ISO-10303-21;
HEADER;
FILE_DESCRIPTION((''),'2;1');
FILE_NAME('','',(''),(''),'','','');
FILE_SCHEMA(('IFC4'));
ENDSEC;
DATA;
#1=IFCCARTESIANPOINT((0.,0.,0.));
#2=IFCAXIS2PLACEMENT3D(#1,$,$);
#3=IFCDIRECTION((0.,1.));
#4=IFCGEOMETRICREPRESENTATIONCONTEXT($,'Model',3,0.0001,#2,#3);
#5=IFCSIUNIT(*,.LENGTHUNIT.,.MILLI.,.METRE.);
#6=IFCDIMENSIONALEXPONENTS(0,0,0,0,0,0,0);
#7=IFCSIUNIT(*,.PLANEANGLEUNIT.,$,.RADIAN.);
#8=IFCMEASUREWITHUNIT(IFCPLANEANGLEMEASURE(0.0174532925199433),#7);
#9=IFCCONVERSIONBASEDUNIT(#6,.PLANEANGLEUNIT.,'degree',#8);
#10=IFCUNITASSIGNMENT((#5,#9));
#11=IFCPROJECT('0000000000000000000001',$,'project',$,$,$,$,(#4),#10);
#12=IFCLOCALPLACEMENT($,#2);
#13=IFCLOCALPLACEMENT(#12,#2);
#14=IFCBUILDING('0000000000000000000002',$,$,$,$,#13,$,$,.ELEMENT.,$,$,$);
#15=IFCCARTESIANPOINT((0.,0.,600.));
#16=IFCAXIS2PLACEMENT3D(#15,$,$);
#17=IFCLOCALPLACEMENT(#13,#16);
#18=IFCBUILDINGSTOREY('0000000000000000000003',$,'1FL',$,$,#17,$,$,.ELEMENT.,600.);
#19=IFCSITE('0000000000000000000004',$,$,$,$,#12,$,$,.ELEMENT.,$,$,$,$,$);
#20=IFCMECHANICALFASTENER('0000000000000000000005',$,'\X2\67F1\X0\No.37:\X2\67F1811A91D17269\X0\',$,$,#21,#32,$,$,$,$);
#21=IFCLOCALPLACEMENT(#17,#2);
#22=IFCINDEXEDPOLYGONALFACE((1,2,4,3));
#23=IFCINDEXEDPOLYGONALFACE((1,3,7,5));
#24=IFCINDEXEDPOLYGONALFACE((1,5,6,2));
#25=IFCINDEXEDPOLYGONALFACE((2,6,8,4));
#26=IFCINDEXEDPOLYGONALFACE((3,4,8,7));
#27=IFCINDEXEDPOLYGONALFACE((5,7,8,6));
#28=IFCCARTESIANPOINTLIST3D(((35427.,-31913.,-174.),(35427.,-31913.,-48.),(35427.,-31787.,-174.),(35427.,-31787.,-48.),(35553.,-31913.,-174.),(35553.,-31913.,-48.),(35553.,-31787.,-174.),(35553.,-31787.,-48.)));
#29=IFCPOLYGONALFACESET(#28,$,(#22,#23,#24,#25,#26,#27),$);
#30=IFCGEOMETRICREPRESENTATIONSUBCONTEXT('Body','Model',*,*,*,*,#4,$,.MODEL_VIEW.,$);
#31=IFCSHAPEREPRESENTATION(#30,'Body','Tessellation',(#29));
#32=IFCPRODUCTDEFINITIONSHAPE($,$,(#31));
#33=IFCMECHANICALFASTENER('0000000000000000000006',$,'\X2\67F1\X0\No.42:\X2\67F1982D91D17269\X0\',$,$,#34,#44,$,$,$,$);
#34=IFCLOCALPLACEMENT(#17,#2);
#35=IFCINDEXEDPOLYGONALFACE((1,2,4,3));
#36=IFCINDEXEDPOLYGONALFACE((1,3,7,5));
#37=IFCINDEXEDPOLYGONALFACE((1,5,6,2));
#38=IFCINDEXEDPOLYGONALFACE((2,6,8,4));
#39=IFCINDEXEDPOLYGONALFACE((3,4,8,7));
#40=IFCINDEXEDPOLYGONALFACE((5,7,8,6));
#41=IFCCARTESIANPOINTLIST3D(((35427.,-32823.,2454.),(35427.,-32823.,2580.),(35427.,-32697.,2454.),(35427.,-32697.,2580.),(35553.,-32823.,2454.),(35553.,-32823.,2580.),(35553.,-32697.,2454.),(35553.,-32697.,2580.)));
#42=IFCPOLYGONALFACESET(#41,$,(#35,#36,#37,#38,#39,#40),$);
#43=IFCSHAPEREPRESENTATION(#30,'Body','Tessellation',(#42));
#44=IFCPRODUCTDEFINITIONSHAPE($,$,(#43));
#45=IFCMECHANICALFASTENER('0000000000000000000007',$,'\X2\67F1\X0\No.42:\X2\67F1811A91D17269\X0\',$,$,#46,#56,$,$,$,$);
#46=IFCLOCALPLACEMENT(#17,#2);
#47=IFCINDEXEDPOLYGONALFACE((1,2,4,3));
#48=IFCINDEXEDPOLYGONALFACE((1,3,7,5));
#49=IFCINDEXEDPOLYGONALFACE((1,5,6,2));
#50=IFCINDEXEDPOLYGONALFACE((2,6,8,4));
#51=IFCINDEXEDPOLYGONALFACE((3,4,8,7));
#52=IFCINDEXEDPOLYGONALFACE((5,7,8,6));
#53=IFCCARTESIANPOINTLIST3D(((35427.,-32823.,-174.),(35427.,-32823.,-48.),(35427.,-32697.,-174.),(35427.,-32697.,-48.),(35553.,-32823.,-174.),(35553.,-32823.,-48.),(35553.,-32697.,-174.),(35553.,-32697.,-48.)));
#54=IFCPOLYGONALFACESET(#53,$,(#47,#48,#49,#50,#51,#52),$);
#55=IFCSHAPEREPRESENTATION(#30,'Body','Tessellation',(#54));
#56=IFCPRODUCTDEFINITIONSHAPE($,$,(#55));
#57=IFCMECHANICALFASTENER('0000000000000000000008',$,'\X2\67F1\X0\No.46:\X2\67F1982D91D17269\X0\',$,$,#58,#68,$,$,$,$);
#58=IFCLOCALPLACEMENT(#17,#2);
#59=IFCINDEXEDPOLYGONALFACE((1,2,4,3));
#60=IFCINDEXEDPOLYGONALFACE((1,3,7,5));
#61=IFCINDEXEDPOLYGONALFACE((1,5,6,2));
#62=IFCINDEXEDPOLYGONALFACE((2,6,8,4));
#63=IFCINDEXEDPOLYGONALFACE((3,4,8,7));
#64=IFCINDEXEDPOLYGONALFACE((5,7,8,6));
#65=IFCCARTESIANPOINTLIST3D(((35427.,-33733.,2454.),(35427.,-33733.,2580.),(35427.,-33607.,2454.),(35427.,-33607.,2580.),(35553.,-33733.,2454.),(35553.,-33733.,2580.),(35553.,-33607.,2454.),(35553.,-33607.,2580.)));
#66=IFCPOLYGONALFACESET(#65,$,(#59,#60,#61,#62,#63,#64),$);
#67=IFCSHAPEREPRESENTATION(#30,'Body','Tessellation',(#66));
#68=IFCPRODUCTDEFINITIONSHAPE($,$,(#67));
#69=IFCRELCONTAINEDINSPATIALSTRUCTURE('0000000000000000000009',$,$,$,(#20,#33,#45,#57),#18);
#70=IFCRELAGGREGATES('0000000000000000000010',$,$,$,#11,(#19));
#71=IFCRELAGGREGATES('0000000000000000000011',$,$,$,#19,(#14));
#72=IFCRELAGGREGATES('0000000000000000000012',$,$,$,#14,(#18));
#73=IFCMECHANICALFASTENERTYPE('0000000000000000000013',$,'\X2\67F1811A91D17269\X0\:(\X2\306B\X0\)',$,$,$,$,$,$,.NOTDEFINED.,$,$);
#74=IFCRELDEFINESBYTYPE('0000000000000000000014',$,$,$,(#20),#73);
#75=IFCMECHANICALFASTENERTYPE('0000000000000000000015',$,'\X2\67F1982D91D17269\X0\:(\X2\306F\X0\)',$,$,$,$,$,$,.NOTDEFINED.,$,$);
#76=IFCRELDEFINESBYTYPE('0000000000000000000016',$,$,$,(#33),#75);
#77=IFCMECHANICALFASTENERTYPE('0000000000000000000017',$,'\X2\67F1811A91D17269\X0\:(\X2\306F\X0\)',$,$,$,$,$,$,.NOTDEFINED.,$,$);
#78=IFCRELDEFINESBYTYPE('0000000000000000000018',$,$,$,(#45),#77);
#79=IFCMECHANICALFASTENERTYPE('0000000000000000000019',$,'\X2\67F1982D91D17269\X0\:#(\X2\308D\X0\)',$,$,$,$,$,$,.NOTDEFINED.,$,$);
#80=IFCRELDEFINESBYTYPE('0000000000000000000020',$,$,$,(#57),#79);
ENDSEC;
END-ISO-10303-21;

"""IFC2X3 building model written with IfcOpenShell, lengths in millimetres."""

from ifc_helpers import new_model, entity, si_unit, converted_unit, direction, frame, origin, origin_with_axes, origin_2d, place, context, subcontext, project, spatial, rectangle, extrude, type_object, element, save


model = new_model("IFC2X3")

# Units and contexts
model_context = context("Model", 3, precision=0.0001, world=origin(), true_north=direction((0.0, 1.0)))
body_context = subcontext(model_context, "Body", "Model", "MODEL_VIEW")
ifc_project = project(units=[si_unit("LENGTHUNIT", "METRE", prefix="MILLI"), converted_unit("PLANEANGLEUNIT", "degree", entity("IfcPlaneAngleMeasure", 0.0174532925199433), si_unit("PLANEANGLEUNIT", "RADIAN"), dimensions=[0, 0, 0, 0, 0, 0, 0])], contexts=[model_context])

# Site, building, storey
site_placement = place(None, origin())
site = spatial("IfcSite", under=ifc_project, at=site_placement, CompositionType="ELEMENT")
building_placement = place(site_placement, origin())
building = spatial("IfcBuilding", under=site, at=building_placement, CompositionType="ELEMENT")
storey_placement = place(building_placement, frame((0.0, 0.0, 600.0)))
storey = spatial("IfcBuildingStorey", under=building, at=storey_placement, Name="1FL", CompositionType="ELEMENT", Elevation=600.0)

# Mechanical fasteners
mechanical_fastener_type_1 = type_object("IfcMechanicalFastenerType", Name="柱脚金物:(に)")
mechanical_fastener_1_placement = place(storey_placement, frame((35490.0, -31850.0, -174.0)))
element("IfcMechanicalFastener", 1, at=mechanical_fastener_1_placement, inside=storey, type_object=mechanical_fastener_type_1, Name="柱No.37:柱脚金物", context=body_context, shape_type="SweptSolid", body=[
    extrude(rectangle(XDim=126.0, YDim=126.0, at=origin_2d()), origin_with_axes(), (0.0, 0.0, 1.0), 126.0),
])
mechanical_fastener_type_2 = type_object("IfcMechanicalFastenerType", Name="柱頭金物:(は)")
mechanical_fastener_2_placement = place(storey_placement, frame((35490.0, -32760.0, 2454.0)))
element("IfcMechanicalFastener", 2, at=mechanical_fastener_2_placement, inside=storey, type_object=mechanical_fastener_type_2, Name="柱No.42:柱頭金物", context=body_context, shape_type="SweptSolid", body=[
    extrude(rectangle(XDim=126.0, YDim=126.0, at=origin_2d()), origin_with_axes(), (0.0, 0.0, 1.0), 126.0),
])
mechanical_fastener_type_3 = type_object("IfcMechanicalFastenerType", Name="柱脚金物:(は)")
mechanical_fastener_3_placement = place(storey_placement, frame((35490.0, -32760.0, -174.0)))
element("IfcMechanicalFastener", 3, at=mechanical_fastener_3_placement, inside=storey, type_object=mechanical_fastener_type_3, Name="柱No.42:柱脚金物", context=body_context, shape_type="SweptSolid", body=[
    extrude(rectangle(XDim=126.0, YDim=126.0, at=origin_2d()), origin_with_axes(), (0.0, 0.0, 1.0), 126.0),
])
mechanical_fastener_type_4 = type_object("IfcMechanicalFastenerType", Name="柱頭金物:#(ろ)")
mechanical_fastener_4_placement = place(storey_placement, frame((35490.0, -33670.0, 2454.0)))
element("IfcMechanicalFastener", 4, at=mechanical_fastener_4_placement, inside=storey, type_object=mechanical_fastener_type_4, Name="柱No.46:柱頭金物", context=body_context, shape_type="SweptSolid", body=[
    extrude(rectangle(XDim=126.0, YDim=126.0, at=origin_2d()), origin_with_axes(), (0.0, 0.0, 1.0), 126.0),
])

save(model, "model.ifc")
